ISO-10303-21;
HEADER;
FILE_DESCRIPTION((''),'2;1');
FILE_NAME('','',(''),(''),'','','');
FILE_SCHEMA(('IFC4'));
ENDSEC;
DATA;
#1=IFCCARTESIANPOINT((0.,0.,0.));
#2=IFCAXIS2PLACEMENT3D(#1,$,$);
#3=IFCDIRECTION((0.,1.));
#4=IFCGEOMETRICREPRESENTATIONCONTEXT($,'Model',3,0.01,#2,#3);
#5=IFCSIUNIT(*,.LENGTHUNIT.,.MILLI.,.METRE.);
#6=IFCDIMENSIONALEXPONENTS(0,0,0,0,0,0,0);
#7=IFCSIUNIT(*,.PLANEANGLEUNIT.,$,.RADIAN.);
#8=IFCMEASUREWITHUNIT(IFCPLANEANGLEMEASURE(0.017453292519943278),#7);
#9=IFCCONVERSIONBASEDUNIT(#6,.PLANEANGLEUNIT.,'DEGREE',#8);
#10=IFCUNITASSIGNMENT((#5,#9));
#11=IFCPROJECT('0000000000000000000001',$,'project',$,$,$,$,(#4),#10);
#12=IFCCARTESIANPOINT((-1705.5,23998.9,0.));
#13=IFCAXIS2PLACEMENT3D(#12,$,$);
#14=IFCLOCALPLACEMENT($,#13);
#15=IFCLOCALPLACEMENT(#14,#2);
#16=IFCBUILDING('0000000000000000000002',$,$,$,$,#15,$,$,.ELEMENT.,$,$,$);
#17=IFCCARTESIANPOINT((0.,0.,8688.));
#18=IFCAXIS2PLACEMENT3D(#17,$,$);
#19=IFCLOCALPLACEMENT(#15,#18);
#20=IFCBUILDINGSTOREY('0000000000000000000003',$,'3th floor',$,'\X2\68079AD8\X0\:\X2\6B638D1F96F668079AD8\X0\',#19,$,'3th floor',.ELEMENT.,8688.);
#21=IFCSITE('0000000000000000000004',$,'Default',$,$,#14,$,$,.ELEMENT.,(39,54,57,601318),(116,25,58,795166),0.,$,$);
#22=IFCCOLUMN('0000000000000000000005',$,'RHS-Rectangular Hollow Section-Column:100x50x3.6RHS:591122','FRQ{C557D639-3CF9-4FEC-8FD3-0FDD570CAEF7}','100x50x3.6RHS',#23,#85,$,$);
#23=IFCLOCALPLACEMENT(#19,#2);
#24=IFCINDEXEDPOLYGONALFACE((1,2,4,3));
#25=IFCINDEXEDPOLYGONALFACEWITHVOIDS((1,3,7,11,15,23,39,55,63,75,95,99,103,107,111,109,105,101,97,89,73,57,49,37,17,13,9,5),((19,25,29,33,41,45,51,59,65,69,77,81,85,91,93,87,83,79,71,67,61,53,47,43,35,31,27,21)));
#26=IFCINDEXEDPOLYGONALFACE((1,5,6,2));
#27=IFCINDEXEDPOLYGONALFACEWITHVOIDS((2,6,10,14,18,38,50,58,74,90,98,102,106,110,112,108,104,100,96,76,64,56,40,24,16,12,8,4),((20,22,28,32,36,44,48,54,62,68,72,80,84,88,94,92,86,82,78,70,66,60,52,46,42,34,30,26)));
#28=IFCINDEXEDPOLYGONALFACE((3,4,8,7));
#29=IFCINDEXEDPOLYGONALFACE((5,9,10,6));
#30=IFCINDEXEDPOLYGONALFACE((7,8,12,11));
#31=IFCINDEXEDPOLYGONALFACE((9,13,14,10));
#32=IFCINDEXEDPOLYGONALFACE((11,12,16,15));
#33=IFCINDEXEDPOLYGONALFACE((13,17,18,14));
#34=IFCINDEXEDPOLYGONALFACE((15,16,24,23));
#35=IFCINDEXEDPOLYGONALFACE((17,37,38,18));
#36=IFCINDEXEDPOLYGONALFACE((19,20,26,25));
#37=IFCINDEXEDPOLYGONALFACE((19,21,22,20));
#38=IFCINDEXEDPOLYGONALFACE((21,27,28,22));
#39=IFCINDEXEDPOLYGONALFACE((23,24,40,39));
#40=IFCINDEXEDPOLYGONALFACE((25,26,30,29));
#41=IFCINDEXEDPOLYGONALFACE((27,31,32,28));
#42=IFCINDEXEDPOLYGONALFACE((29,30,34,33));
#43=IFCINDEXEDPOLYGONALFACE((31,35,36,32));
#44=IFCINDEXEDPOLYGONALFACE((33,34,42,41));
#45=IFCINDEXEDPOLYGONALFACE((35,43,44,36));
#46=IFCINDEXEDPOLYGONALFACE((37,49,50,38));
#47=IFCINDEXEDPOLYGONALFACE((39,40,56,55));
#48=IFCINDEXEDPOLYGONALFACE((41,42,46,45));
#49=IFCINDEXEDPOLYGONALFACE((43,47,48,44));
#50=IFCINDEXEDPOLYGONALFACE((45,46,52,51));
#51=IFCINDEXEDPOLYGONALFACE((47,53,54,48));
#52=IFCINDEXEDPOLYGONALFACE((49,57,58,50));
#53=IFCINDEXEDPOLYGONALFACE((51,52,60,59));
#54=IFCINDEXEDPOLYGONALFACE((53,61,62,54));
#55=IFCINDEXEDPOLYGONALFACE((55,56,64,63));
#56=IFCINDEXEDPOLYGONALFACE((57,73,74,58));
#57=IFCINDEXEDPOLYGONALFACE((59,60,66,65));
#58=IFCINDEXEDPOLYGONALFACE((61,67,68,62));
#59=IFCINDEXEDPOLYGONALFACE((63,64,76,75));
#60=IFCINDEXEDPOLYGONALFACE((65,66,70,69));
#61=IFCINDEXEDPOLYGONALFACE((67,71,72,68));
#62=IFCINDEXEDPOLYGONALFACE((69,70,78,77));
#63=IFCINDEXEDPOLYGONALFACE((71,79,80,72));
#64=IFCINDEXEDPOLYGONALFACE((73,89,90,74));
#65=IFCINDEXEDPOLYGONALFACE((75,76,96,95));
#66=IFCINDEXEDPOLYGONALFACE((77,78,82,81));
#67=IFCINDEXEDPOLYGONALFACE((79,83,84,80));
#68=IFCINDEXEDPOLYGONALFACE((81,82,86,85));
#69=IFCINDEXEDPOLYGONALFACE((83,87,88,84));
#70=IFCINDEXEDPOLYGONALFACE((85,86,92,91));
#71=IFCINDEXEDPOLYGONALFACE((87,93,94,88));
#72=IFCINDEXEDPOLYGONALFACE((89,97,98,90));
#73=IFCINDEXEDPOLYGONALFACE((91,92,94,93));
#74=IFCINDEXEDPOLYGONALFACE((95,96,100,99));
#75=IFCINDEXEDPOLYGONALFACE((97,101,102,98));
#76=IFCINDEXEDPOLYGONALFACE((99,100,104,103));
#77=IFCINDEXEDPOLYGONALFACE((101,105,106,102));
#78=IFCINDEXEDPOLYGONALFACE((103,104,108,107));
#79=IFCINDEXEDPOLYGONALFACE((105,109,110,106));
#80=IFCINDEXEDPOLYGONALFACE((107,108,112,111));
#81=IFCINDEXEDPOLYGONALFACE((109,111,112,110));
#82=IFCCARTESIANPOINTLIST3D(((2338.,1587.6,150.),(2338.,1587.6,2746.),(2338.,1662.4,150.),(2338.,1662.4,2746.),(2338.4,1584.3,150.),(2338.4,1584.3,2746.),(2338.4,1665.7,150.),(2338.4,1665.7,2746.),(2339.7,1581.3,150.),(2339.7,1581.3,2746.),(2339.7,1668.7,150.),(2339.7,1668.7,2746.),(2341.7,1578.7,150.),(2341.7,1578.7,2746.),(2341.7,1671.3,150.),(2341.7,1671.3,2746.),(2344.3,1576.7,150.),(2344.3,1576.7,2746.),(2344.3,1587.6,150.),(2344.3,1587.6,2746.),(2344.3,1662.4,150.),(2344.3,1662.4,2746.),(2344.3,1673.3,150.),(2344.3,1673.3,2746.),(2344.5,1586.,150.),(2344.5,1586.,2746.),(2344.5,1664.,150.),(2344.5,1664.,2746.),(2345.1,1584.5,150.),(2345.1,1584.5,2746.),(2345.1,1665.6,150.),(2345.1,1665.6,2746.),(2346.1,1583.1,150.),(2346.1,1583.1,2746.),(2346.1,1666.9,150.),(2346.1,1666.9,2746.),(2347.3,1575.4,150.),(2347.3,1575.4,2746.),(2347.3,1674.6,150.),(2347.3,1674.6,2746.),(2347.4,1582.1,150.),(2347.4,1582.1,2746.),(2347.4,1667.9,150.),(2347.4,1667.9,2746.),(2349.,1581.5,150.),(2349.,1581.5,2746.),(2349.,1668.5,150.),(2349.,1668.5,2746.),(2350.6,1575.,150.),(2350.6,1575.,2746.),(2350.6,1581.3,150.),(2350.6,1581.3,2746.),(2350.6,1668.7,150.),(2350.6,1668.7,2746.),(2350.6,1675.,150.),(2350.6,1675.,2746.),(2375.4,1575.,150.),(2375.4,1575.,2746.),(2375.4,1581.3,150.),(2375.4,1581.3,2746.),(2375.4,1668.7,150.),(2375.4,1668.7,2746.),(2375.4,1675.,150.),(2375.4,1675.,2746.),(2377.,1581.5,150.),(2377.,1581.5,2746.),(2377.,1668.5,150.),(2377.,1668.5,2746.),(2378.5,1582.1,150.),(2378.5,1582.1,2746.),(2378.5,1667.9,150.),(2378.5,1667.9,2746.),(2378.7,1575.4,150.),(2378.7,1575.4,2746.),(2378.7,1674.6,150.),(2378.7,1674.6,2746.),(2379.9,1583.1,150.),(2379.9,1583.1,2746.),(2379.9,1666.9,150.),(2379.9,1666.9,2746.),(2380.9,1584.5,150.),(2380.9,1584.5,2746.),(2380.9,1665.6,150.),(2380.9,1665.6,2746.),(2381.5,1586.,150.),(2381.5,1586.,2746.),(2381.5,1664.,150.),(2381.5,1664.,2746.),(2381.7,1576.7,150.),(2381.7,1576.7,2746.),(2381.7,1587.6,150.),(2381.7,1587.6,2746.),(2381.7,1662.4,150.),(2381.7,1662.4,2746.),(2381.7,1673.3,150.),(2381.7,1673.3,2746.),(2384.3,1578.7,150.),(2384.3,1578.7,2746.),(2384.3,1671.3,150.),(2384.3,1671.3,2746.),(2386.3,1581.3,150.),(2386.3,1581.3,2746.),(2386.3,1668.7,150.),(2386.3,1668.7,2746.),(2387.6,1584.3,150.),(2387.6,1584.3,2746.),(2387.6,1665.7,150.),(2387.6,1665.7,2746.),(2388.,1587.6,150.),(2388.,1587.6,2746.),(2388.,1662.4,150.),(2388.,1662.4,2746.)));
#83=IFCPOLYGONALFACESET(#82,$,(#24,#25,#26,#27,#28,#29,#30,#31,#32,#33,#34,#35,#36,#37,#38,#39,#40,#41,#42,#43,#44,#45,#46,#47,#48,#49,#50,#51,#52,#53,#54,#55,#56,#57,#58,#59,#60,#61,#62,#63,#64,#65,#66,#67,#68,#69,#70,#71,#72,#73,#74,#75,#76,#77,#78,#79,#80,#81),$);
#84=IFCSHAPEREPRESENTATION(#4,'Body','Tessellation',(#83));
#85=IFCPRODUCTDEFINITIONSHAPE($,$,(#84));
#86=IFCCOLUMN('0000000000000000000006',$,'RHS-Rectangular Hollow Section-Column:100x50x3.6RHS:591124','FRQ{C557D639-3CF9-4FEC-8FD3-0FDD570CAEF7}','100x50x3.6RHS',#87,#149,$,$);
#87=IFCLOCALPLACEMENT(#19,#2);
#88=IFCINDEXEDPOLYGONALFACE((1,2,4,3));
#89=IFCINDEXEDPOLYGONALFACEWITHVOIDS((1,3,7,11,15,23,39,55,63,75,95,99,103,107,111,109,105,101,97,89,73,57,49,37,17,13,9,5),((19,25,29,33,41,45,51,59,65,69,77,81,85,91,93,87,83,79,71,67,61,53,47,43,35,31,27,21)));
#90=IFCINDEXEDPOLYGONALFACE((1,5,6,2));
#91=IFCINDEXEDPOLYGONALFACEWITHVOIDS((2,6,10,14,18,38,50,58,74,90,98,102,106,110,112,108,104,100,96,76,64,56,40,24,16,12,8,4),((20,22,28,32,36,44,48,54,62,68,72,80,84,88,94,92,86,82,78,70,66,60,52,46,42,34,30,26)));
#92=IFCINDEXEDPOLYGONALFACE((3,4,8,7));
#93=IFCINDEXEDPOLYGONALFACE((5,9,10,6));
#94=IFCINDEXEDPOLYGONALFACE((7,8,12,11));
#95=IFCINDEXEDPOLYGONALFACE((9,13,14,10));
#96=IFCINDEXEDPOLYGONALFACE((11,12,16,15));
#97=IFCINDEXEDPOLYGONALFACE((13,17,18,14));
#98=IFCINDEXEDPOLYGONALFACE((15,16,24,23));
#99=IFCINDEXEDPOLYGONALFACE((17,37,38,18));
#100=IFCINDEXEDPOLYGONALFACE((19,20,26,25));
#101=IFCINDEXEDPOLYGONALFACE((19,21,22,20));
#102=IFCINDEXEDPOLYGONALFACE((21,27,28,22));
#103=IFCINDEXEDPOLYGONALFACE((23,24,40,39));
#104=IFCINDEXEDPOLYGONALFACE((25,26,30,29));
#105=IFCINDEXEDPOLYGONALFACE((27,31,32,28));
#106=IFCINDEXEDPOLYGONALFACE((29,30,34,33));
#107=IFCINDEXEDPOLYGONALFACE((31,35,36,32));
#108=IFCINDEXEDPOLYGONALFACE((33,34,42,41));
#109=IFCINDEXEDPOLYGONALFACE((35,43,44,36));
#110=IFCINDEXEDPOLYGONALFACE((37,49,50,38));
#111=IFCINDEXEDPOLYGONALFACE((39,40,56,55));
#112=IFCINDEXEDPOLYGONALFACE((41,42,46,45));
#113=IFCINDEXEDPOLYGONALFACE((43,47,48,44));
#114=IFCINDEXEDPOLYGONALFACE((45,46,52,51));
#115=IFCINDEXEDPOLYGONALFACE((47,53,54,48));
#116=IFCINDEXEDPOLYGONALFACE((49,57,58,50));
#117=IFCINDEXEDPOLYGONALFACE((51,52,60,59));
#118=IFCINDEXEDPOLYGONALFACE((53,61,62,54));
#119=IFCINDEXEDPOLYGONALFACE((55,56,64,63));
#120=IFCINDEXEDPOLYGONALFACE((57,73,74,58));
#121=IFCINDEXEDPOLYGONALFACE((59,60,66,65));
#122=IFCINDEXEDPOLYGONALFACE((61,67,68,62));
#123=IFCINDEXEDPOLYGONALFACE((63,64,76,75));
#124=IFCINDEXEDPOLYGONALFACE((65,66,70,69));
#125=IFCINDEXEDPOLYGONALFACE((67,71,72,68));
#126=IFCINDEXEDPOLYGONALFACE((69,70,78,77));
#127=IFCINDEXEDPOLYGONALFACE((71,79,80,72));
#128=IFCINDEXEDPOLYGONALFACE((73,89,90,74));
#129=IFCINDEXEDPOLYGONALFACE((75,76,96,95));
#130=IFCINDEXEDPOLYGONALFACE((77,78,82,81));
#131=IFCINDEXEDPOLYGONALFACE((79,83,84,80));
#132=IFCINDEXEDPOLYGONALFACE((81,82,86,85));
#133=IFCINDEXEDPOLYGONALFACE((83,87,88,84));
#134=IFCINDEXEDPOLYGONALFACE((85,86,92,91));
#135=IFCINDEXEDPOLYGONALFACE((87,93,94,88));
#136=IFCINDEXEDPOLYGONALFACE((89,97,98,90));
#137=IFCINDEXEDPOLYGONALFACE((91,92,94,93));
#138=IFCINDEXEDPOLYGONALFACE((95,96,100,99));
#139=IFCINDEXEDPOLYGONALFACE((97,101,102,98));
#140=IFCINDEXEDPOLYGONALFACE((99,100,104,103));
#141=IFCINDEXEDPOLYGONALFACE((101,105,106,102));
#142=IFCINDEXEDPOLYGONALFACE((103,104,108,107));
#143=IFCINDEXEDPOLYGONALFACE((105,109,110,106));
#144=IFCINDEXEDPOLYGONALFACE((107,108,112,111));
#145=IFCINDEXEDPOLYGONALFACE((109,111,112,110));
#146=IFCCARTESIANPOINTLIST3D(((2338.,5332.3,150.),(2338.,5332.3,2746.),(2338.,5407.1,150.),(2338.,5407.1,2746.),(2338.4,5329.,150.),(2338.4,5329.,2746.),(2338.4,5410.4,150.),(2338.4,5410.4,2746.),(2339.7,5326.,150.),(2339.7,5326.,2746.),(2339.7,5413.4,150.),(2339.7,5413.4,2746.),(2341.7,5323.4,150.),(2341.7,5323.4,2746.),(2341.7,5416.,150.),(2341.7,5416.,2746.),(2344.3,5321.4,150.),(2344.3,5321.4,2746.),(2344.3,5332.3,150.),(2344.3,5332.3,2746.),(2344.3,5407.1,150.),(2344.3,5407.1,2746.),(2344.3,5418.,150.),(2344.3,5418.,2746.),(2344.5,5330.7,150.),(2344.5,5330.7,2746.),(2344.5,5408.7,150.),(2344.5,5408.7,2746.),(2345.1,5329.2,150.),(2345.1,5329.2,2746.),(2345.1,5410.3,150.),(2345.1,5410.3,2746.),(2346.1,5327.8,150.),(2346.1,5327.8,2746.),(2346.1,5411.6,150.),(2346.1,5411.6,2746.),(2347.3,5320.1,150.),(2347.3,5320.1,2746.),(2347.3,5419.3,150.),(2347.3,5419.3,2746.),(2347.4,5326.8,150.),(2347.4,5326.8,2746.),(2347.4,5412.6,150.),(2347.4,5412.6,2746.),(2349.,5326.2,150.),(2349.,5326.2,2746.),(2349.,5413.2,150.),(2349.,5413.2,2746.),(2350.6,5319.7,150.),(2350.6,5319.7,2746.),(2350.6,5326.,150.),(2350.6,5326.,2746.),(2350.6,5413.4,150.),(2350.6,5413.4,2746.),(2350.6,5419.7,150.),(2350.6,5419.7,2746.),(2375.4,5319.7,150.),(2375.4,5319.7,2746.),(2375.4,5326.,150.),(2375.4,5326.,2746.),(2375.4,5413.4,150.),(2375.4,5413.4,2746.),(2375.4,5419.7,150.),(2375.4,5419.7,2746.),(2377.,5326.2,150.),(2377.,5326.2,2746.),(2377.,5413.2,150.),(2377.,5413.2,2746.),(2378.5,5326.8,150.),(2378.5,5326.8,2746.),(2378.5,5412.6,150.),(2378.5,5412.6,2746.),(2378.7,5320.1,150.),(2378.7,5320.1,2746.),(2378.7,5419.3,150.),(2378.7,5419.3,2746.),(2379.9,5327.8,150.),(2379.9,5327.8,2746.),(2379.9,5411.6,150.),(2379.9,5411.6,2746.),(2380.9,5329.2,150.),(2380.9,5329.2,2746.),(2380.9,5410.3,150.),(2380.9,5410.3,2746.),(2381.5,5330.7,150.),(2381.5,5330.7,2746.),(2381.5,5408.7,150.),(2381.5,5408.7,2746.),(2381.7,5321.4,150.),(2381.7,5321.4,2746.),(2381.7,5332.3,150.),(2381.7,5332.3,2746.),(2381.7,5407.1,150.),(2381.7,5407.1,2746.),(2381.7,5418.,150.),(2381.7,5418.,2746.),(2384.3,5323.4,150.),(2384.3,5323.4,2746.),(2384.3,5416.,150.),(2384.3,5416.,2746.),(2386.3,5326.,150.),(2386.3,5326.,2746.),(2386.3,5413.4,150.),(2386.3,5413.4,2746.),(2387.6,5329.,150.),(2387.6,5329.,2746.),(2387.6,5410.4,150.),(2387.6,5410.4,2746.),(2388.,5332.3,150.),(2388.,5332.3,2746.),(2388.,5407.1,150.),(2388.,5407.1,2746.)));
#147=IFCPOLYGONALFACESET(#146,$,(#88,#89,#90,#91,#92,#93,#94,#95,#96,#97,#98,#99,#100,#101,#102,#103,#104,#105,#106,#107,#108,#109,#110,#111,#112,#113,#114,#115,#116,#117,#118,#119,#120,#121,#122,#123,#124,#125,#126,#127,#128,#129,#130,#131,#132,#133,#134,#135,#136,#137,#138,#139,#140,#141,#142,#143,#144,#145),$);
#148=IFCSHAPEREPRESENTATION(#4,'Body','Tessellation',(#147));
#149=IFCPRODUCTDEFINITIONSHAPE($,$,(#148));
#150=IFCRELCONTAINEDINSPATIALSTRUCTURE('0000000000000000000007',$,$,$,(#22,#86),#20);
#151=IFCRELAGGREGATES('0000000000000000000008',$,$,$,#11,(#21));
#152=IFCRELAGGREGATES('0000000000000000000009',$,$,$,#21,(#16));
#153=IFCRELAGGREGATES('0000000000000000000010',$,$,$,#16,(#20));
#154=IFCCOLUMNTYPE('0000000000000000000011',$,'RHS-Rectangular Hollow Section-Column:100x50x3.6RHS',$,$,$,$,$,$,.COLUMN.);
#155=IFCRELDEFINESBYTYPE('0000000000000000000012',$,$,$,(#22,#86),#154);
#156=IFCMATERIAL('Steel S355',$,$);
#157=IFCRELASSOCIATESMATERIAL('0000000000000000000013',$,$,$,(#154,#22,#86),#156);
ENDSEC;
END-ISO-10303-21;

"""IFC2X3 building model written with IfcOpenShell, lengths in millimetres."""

from ifc_helpers import new_model, entity, si_unit, converted_unit, direction, frame, origin, origin_2d, place, context, project, spatial, hollow_rectangle, extrude, clip, halfspace, material, type_object, element, save


model = new_model("IFC2X3")

# Units and contexts
model_context = context("Model", 3, precision=0.01, world=origin(), true_north=direction((0.0, 1.0)))
ifc_project = project(units=[si_unit("LENGTHUNIT", "METRE", prefix="MILLI"), converted_unit("PLANEANGLEUNIT", "DEGREE", entity("IfcPlaneAngleMeasure", 0.017453292519943278), si_unit("PLANEANGLEUNIT", "RADIAN"), dimensions=[0, 0, 0, 0, 0, 0, 0])], contexts=[model_context])

# Site, building, storey
site_placement = place(None, frame((-1705.5, 23998.9, 0.0)))
site = spatial("IfcSite", under=ifc_project, at=site_placement, Name="Default", CompositionType="ELEMENT", RefLatitude=(39, 54, 57, 601318), RefLongitude=(116, 25, 58, 795166), RefElevation=0.0)
building_placement = place(site_placement, origin())
building = spatial("IfcBuilding", under=site, at=building_placement, CompositionType="ELEMENT")
storey_placement = place(building_placement, frame((0.0, 0.0, 8688.0)))
storey = spatial("IfcBuildingStorey", under=building, at=storey_placement, Name="3th floor", ObjectType="标高:正负零标高", LongName="3th floor", CompositionType="ELEMENT", Elevation=8688.0)

# Columns
ifc_material_1 = material(Name="Steel S355")
column_type_1 = type_object("IfcColumnType", Name="RHS-Rectangular Hollow Section-Column:100x50x3.6RHS", PredefinedType="COLUMN", material=ifc_material_1)
column_1_placement = place(storey_placement, frame((2363.0, 1625.0, 2746.0), z_axis=(0.0, 0.0, 1.0), x_axis=(-1.0, 0.0, 0.0)))
element("IfcColumn", 1, at=column_1_placement, inside=storey, type_object=column_type_1, material=ifc_material_1, Name="RHS-Rectangular Hollow Section-Column:100x50x3.6RHS:591122", Description="FRQ{C557D639-3CF9-4FEC-8FD3-0FDD570CAEF7}", ObjectType="100x50x3.6RHS", context=model_context, shape_type="Clipping", body=[
    clip(extrude(hollow_rectangle(XDim=50.0, YDim=100.0, WallThickness=6.3, InnerFilletRadius=6.3, OuterFilletRadius=12.6, at=origin_2d()), origin(), (0.0, 0.0, -1.0), 2651.9), halfspace(frame((2363.0, 1625.0, -2596.0), z_axis=(0.0, 0.0, 1.0), x_axis=(-1.0, 0.0, 0.0)), True)),
])
column_2_placement = place(storey_placement, frame((2363.0, 5369.7, 2746.0), z_axis=(0.0, 0.0, 1.0), x_axis=(-1.0, 0.0, 0.0)))
element("IfcColumn", 2, at=column_2_placement, inside=storey, type_object=column_type_1, material=ifc_material_1, Name="RHS-Rectangular Hollow Section-Column:100x50x3.6RHS:591124", Description="FRQ{C557D639-3CF9-4FEC-8FD3-0FDD570CAEF7}", ObjectType="100x50x3.6RHS", context=model_context, shape_type="Clipping", body=[
    clip(extrude(hollow_rectangle(XDim=50.0, YDim=100.0, WallThickness=6.3, InnerFilletRadius=6.3, OuterFilletRadius=12.6, at=origin_2d()), origin(), (0.0, 0.0, -1.0), 2651.9), halfspace(frame((2363.0, 5369.7, -2596.0), z_axis=(0.0, 0.0, 1.0), x_axis=(-1.0, 0.0, 0.0)), True)),
])

save(model, "model.ifc")
